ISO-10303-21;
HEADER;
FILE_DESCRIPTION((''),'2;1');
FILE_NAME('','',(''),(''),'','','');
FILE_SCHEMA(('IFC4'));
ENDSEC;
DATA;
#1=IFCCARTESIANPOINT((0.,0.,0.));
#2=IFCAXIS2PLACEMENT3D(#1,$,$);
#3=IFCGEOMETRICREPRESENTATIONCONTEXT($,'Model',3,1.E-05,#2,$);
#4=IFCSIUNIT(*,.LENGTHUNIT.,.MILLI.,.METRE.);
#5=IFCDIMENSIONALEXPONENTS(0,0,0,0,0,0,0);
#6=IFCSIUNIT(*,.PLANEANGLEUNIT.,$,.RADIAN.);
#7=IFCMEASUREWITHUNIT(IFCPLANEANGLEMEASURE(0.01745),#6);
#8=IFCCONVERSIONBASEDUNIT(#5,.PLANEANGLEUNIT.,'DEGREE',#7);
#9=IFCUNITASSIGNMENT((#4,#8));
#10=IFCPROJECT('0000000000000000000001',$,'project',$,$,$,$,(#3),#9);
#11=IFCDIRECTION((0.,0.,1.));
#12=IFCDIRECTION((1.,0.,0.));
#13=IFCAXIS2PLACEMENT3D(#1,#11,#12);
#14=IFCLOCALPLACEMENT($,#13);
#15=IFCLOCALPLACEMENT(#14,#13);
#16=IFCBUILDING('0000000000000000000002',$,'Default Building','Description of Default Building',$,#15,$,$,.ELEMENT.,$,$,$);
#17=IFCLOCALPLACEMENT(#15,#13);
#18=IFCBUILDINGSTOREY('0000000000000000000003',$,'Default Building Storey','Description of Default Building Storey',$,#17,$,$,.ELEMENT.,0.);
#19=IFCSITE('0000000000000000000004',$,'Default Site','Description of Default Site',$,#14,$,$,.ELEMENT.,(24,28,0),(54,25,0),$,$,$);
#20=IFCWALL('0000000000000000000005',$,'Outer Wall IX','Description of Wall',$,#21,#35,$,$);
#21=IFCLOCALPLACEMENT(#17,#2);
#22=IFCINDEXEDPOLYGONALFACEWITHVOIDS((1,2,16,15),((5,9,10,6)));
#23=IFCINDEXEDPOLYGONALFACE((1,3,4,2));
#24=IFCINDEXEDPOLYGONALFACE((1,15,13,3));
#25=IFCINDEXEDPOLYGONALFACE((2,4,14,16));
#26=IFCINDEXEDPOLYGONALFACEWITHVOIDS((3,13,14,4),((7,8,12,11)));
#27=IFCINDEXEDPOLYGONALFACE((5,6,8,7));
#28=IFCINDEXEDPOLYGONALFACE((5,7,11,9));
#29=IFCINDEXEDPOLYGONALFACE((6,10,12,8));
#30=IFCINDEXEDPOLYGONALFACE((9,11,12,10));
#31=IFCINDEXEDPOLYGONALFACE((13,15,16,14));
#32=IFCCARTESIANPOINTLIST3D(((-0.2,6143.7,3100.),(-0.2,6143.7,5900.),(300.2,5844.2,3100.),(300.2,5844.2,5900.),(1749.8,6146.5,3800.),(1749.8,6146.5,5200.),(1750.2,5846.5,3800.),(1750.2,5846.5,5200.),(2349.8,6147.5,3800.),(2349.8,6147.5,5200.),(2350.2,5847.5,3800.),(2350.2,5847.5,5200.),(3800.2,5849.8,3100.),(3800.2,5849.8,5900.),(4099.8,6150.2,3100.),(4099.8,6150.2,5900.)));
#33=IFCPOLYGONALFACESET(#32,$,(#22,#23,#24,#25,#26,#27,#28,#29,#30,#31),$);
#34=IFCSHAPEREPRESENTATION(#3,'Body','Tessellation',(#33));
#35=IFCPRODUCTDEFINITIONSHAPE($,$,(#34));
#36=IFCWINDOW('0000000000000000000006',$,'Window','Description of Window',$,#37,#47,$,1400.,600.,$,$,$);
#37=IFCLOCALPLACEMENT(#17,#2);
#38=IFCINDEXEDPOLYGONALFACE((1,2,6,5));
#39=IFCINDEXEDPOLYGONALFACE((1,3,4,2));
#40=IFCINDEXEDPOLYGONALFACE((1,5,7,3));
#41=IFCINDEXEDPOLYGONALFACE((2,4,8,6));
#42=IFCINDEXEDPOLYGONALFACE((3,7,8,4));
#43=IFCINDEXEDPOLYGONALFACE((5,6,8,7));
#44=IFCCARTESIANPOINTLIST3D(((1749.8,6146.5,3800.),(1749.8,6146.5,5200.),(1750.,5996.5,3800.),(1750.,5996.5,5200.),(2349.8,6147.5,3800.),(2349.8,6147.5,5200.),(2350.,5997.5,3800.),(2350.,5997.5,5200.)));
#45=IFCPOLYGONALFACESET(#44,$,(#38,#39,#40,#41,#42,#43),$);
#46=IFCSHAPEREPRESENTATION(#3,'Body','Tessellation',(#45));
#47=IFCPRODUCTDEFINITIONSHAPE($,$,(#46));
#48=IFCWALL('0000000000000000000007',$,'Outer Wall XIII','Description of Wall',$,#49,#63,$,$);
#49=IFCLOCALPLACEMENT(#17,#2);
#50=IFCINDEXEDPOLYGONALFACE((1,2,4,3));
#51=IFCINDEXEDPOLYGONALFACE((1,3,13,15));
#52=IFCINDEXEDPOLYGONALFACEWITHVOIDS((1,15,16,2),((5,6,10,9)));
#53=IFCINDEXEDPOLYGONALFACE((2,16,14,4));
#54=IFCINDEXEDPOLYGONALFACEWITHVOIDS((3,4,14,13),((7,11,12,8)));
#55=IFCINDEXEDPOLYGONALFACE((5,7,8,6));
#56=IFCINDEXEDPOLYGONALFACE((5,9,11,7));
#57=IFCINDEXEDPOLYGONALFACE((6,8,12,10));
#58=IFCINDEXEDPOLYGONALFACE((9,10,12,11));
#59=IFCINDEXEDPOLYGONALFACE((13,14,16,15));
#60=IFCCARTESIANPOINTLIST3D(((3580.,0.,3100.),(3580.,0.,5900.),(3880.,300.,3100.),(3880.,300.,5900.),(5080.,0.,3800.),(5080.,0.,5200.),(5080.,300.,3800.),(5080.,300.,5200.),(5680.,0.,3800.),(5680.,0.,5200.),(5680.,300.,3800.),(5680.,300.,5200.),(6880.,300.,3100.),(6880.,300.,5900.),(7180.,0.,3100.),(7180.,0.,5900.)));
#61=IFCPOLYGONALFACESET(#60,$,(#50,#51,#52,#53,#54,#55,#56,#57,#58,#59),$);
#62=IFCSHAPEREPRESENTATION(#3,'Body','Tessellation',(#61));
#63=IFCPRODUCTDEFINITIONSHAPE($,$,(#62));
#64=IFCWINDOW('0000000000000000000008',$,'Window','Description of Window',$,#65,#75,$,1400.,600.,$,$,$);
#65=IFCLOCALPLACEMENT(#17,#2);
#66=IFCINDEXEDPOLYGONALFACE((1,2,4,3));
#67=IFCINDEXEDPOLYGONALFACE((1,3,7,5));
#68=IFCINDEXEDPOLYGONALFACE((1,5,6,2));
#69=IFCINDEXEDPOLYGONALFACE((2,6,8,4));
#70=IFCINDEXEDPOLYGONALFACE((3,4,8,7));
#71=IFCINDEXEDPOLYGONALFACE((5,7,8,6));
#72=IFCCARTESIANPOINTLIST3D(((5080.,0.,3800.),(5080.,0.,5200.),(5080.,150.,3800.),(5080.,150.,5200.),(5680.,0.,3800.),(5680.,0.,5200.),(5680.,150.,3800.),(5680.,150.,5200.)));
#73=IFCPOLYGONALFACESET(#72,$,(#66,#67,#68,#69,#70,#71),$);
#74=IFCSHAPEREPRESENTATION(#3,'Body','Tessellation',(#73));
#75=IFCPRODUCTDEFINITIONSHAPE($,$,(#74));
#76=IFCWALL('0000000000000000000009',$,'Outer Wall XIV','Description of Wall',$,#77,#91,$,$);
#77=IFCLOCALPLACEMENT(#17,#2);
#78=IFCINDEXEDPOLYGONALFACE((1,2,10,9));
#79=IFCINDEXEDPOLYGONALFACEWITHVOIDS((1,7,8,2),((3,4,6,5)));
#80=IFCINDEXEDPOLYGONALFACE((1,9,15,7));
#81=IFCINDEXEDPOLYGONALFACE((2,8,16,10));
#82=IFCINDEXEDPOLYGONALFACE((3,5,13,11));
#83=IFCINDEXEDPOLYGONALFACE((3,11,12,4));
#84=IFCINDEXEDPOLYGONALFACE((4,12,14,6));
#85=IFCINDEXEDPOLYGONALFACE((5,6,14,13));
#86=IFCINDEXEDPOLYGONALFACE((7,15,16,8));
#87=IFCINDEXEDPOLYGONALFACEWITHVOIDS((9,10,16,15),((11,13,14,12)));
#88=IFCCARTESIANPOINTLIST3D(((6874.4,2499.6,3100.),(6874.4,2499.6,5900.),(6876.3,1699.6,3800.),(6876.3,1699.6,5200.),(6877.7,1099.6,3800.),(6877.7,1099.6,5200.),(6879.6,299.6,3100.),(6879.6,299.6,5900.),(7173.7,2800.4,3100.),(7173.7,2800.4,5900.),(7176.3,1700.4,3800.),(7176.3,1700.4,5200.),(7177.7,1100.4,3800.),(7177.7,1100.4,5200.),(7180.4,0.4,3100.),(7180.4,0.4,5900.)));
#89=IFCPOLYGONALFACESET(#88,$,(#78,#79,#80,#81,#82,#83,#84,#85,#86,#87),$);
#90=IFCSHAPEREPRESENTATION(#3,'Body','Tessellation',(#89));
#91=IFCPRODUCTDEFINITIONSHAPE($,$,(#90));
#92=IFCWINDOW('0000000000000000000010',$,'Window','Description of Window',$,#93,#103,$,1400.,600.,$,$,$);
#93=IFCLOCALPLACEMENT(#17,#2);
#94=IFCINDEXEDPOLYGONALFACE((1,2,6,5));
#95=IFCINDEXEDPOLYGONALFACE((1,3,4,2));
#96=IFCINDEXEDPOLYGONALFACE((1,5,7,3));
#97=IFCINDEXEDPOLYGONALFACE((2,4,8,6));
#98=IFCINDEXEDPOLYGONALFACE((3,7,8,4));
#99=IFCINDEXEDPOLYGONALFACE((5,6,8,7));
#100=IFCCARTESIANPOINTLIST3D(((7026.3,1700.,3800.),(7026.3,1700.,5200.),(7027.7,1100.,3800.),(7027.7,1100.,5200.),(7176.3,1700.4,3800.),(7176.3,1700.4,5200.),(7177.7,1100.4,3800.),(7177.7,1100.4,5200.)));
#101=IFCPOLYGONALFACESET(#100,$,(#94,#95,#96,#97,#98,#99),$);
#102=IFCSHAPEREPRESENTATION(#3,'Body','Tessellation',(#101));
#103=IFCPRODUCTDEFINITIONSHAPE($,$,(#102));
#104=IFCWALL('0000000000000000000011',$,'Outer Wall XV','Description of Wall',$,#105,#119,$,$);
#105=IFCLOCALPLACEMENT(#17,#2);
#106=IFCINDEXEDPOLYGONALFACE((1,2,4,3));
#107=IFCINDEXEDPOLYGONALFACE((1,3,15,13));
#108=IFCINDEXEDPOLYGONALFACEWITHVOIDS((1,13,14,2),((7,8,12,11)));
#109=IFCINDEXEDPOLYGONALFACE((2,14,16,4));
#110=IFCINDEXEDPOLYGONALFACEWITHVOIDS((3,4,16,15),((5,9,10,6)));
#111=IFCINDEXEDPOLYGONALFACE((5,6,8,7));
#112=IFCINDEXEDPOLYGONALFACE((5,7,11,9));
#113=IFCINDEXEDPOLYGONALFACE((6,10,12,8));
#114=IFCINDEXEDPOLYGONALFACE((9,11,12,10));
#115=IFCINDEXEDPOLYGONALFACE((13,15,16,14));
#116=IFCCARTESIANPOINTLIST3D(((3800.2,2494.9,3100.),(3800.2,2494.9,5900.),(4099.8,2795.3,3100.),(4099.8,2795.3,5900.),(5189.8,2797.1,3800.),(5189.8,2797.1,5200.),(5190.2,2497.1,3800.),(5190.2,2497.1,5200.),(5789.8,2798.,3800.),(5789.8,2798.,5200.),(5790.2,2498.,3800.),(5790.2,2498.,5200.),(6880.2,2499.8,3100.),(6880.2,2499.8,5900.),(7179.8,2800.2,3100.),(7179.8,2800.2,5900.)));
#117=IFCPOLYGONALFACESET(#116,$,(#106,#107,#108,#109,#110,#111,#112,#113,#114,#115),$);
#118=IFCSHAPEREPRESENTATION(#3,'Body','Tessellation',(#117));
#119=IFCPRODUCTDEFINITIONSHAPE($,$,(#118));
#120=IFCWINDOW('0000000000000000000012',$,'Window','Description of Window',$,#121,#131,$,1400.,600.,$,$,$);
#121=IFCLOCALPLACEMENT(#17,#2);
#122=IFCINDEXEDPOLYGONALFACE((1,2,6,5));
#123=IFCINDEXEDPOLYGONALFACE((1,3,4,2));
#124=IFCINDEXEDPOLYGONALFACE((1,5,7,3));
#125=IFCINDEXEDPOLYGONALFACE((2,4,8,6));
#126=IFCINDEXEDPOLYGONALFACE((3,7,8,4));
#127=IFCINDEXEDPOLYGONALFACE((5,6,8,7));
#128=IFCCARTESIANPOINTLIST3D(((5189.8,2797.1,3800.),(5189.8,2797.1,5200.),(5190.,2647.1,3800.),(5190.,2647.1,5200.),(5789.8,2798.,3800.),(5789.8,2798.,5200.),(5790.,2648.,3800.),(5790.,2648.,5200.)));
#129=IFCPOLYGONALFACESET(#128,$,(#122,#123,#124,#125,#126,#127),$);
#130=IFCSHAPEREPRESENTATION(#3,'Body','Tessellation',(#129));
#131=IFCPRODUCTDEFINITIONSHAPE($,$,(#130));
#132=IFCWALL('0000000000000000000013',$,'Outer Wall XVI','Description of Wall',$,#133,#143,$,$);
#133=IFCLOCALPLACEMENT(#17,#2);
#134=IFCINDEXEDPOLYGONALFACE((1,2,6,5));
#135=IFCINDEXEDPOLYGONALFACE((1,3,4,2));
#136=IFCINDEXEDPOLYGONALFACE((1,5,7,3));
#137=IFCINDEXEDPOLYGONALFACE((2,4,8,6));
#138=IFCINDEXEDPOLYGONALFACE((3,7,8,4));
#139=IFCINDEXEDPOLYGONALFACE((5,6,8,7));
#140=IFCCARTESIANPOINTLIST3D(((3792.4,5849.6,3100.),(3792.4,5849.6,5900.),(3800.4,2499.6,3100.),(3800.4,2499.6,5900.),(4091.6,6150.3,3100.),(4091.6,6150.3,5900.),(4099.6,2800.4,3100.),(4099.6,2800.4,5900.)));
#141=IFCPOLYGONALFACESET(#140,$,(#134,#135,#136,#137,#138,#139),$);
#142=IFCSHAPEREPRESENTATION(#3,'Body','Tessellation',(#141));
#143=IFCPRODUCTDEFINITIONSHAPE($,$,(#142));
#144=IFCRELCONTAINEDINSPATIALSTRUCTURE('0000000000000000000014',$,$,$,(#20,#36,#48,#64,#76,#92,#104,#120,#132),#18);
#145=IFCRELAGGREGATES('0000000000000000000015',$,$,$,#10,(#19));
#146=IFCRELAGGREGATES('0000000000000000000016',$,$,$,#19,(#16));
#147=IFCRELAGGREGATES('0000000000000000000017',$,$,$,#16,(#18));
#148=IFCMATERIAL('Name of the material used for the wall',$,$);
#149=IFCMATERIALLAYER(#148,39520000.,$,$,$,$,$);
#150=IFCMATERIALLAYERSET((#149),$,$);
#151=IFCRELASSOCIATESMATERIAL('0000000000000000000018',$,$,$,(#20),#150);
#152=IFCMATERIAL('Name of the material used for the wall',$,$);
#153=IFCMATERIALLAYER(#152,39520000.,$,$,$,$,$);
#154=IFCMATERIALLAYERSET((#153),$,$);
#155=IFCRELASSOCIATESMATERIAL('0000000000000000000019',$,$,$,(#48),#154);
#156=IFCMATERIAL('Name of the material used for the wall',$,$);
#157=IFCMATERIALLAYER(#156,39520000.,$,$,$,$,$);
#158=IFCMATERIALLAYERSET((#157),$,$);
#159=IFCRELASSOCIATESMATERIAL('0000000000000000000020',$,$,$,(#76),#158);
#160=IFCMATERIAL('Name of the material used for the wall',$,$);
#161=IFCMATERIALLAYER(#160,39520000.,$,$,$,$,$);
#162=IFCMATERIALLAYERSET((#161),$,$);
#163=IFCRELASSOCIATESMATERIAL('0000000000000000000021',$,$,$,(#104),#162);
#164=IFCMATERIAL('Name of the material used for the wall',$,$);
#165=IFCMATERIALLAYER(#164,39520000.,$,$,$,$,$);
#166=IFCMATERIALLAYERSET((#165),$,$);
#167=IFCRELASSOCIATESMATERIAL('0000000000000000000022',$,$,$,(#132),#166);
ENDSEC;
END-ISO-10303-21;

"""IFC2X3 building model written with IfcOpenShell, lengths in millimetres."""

from ifc_helpers import new_model, entity, si_unit, converted_unit, frame, origin, origin_with_axes, place, context, project, spatial, polyline, outline, extrude, material, layer, layer_set, layer_usage, element, fill, save


model = new_model("IFC2X3")

# Units and contexts
model_context = context("Model", 3, precision=1e-05, world=origin())
ifc_project = project(units=[si_unit("LENGTHUNIT", "METRE", prefix="MILLI"), converted_unit("PLANEANGLEUNIT", "DEGREE", entity("IfcPlaneAngleMeasure", 0.01745), si_unit("PLANEANGLEUNIT", "RADIAN"), dimensions=[0, 0, 0, 0, 0, 0, 0])], contexts=[model_context])

# Site, building, storey
site_placement = place(None, origin_with_axes())
site = spatial("IfcSite", under=ifc_project, at=site_placement, Name="Default Site", Description="Description of Default Site", CompositionType="ELEMENT", RefLatitude=(24, 28, 0), RefLongitude=(54, 25, 0))
building_placement = place(site_placement, origin_with_axes())
building = spatial("IfcBuilding", under=site, at=building_placement, Name="Default Building", Description="Description of Default Building", CompositionType="ELEMENT")
storey_placement = place(building_placement, origin_with_axes())
storey = spatial("IfcBuildingStorey", under=building, at=storey_placement, Name="Default Building Storey", Description="Description of Default Building Storey", CompositionType="ELEMENT", Elevation=0.0)

# Walls, openings, windows
ifc_material_1 = material(Name="Name of the material used for the wall")
ifc_layer_1 = layer(ifc_material_1, 39520000.0)
ifc_layer_set_1 = layer_set([ifc_layer_1])
ifc_layer_usage_1 = layer_usage(ifc_layer_set_1, "AXIS2", "POSITIVE", -19760000.0)
wall_1_placement = place(storey_placement, frame((3950.0, 6000.0, 3100.0), z_axis=(0.0, 0.0, 1.0), x_axis=(-1.0, -0.001593, 0.0)))
wall_1 = element("IfcWall", 1, at=wall_1_placement, inside=storey, material=ifc_layer_usage_1, Name="Outer Wall IX", Description="Description of Wall", context=model_context, shape_type="SweptSolid", body=[
    extrude(outline(polyline([(-150.0, -150.0), (150.0, 150.0), (3650.0, 150.0), (3950.0, -150.0), (-150.0, -150.0)])), origin_with_axes(), (0.0, 0.0, 1.0), 2800.0),
])
opening_1_placement = place(wall_1_placement, frame((1600.0, -150.0, 700.0), z_axis=(0.0, 0.0, 1.0), x_axis=(1.0, 0.0, 0.0)))
opening_1 = element("IfcOpeningElement", 2, at=opening_1_placement, cuts=wall_1, context=model_context, shape_type="SweptSolid", body=[
    extrude(outline(polyline([(0.0, 0.0), (0.0, 300.0), (600.0, 300.0), (600.0, 0.0), (0.0, 0.0)])), origin_with_axes(), (0.0, 0.0, 1.0), 1400.0),
])
window_1_placement = place(opening_1_placement, origin_with_axes())
window_1 = element("IfcWindow", 3, at=window_1_placement, inside=storey, Name="Window", Description="Description of Window", OverallHeight=1400.0, OverallWidth=600.0, context=model_context, shape_type="SweptSolid", body=[
    extrude(outline(polyline([(0.0, 0.0), (0.0, 150.0), (600.0, 150.0), (600.0, 0.0), (0.0, 0.0)])), origin_with_axes(), (0.0, 0.0, 1.0), 1400.0),
])
fill(opening_1, window_1)
ifc_material_2 = material(Name="Name of the material used for the wall")
ifc_layer_2 = layer(ifc_material_2, 39520000.0)
ifc_layer_set_2 = layer_set([ifc_layer_2])
ifc_layer_usage_2 = layer_usage(ifc_layer_set_2, "AXIS2", "POSITIVE", -19760000.0)
wall_2_placement = place(storey_placement, frame((3730.0, 150.0, 3100.0), z_axis=(0.0, 0.0, 1.0), x_axis=(1.0, 0.0, 0.0)))
wall_2 = element("IfcWall", 4, at=wall_2_placement, inside=storey, material=ifc_layer_usage_2, Name="Outer Wall XIII", Description="Description of Wall", context=model_context, shape_type="SweptSolid", body=[
    extrude(outline(polyline([(-150.0, -150.0), (150.0, 150.0), (3150.0, 150.0), (3450.0, -150.0), (-150.0, -150.0)])), origin_with_axes(), (0.0, 0.0, 1.0), 2800.0),
])
opening_2_placement = place(wall_2_placement, frame((1350.0, -150.0, 700.0), z_axis=(0.0, 0.0, 1.0), x_axis=(1.0, 0.0, 0.0)))
opening_2 = element("IfcOpeningElement", 5, at=opening_2_placement, cuts=wall_2, context=model_context, shape_type="SweptSolid", body=[
    extrude(outline(polyline([(0.0, 0.0), (0.0, 300.0), (600.0, 300.0), (600.0, 0.0), (0.0, 0.0)])), origin_with_axes(), (0.0, 0.0, 1.0), 1400.0),
])
window_2_placement = place(opening_2_placement, origin_with_axes())
window_2 = element("IfcWindow", 6, at=window_2_placement, inside=storey, Name="Window", Description="Description of Window", OverallHeight=1400.0, OverallWidth=600.0, context=model_context, shape_type="SweptSolid", body=[
    extrude(outline(polyline([(0.0, 0.0), (0.0, 150.0), (600.0, 150.0), (600.0, 0.0), (0.0, 0.0)])), origin_with_axes(), (0.0, 0.0, 1.0), 1400.0),
])
fill(opening_2, window_2)
ifc_material_3 = material(Name="Name of the material used for the wall")
ifc_layer_3 = layer(ifc_material_3, 39520000.0)
ifc_layer_set_3 = layer_set([ifc_layer_3])
ifc_layer_usage_3 = layer_usage(ifc_layer_set_3, "AXIS2", "POSITIVE", -19760000.0)
wall_3_placement = place(storey_placement, frame((7030.0, 150.0, 3100.0), z_axis=(0.0, 0.0, 1.0), x_axis=(-0.002389, 1.0, 0.0)))
wall_3 = element("IfcWall", 7, at=wall_3_placement, inside=storey, material=ifc_layer_usage_3, Name="Outer Wall XIV", Description="Description of Wall", context=model_context, shape_type="SweptSolid", body=[
    extrude(outline(polyline([(-150.0, -150.0), (150.0, 150.0), (2350.0, 150.0), (2650.0, -150.0), (-150.0, -150.0)])), origin_with_axes(), (0.0, 0.0, 1.0), 2800.0),
])
opening_3_placement = place(wall_3_placement, frame((950.0, -150.0, 700.0), z_axis=(0.0, 0.0, 1.0), x_axis=(1.0, 0.0, 0.0)))
opening_3 = element("IfcOpeningElement", 8, at=opening_3_placement, cuts=wall_3, context=model_context, shape_type="SweptSolid", body=[
    extrude(outline(polyline([(0.0, 0.0), (0.0, 300.0), (600.0, 300.0), (600.0, 0.0), (0.0, 0.0)])), origin_with_axes(), (0.0, 0.0, 1.0), 1400.0),
])
window_3_placement = place(opening_3_placement, origin_with_axes())
window_3 = element("IfcWindow", 9, at=window_3_placement, inside=storey, Name="Window", Description="Description of Window", OverallHeight=1400.0, OverallWidth=600.0, context=model_context, shape_type="SweptSolid", body=[
    extrude(outline(polyline([(0.0, 0.0), (0.0, 150.0), (600.0, 150.0), (600.0, 0.0), (0.0, 0.0)])), origin_with_axes(), (0.0, 0.0, 1.0), 1400.0),
])
fill(opening_3, window_3)
ifc_material_4 = material(Name="Name of the material used for the wall")
ifc_layer_4 = layer(ifc_material_4, 39520000.0)
ifc_layer_set_4 = layer_set([ifc_layer_4])
ifc_layer_usage_4 = layer_usage(ifc_layer_set_4, "AXIS2", "POSITIVE", -19760000.0)
wall_4_placement = place(storey_placement, frame((7030.0, 2650.0, 3100.0), z_axis=(0.0, 0.0, 1.0), x_axis=(-1.0, -0.001593, 0.0)))
wall_4 = element("IfcWall", 10, at=wall_4_placement, inside=storey, material=ifc_layer_usage_4, Name="Outer Wall XV", Description="Description of Wall", context=model_context, shape_type="SweptSolid", body=[
    extrude(outline(polyline([(-150.0, -150.0), (150.0, 150.0), (3230.0, 150.0), (2930.0, -150.0), (-150.0, -150.0)])), origin_with_axes(), (0.0, 0.0, 1.0), 2800.0),
])
opening_4_placement = place(wall_4_placement, frame((1240.0, -150.0, 700.0), z_axis=(0.0, 0.0, 1.0), x_axis=(1.0, 0.0, 0.0)))
opening_4 = element("IfcOpeningElement", 11, at=opening_4_placement, cuts=wall_4, context=model_context, shape_type="SweptSolid", body=[
    extrude(outline(polyline([(0.0, 0.0), (0.0, 300.0), (600.0, 300.0), (600.0, 0.0), (0.0, 0.0)])), origin_with_axes(), (0.0, 0.0, 1.0), 1400.0),
])
window_4_placement = place(opening_4_placement, origin_with_axes())
window_4 = element("IfcWindow", 12, at=window_4_placement, inside=storey, Name="Window", Description="Description of Window", OverallHeight=1400.0, OverallWidth=600.0, context=model_context, shape_type="SweptSolid", body=[
    extrude(outline(polyline([(0.0, 0.0), (0.0, 150.0), (600.0, 150.0), (600.0, 0.0), (0.0, 0.0)])), origin_with_axes(), (0.0, 0.0, 1.0), 1400.0),
])
fill(opening_4, window_4)

# Wall
ifc_material_5 = material(Name="Name of the material used for the wall")
ifc_layer_5 = layer(ifc_material_5, 39520000.0)
ifc_layer_set_5 = layer_set([ifc_layer_5])
ifc_layer_usage_5 = layer_usage(ifc_layer_set_5, "AXIS2", "POSITIVE", -19760000.0)
wall_5_placement = place(storey_placement, frame((3950.0, 2650.0, 3100.0), z_axis=(0.0, 0.0, 1.0), x_axis=(-0.002389, 1.0, 0.0)))
element("IfcWall", 13, at=wall_5_placement, inside=storey, material=ifc_layer_usage_5, Name="Outer Wall XVI", Description="Description of Wall", context=model_context, shape_type="SweptSolid", body=[
    extrude(outline(polyline([(150.0, -150.0), (-150.0, 150.0), (3200.0, 150.0), (3500.0, -150.0), (150.0, -150.0)])), origin_with_axes(), (0.0, 0.0, 1.0), 2800.0),
])

save(model, "model.ifc")
